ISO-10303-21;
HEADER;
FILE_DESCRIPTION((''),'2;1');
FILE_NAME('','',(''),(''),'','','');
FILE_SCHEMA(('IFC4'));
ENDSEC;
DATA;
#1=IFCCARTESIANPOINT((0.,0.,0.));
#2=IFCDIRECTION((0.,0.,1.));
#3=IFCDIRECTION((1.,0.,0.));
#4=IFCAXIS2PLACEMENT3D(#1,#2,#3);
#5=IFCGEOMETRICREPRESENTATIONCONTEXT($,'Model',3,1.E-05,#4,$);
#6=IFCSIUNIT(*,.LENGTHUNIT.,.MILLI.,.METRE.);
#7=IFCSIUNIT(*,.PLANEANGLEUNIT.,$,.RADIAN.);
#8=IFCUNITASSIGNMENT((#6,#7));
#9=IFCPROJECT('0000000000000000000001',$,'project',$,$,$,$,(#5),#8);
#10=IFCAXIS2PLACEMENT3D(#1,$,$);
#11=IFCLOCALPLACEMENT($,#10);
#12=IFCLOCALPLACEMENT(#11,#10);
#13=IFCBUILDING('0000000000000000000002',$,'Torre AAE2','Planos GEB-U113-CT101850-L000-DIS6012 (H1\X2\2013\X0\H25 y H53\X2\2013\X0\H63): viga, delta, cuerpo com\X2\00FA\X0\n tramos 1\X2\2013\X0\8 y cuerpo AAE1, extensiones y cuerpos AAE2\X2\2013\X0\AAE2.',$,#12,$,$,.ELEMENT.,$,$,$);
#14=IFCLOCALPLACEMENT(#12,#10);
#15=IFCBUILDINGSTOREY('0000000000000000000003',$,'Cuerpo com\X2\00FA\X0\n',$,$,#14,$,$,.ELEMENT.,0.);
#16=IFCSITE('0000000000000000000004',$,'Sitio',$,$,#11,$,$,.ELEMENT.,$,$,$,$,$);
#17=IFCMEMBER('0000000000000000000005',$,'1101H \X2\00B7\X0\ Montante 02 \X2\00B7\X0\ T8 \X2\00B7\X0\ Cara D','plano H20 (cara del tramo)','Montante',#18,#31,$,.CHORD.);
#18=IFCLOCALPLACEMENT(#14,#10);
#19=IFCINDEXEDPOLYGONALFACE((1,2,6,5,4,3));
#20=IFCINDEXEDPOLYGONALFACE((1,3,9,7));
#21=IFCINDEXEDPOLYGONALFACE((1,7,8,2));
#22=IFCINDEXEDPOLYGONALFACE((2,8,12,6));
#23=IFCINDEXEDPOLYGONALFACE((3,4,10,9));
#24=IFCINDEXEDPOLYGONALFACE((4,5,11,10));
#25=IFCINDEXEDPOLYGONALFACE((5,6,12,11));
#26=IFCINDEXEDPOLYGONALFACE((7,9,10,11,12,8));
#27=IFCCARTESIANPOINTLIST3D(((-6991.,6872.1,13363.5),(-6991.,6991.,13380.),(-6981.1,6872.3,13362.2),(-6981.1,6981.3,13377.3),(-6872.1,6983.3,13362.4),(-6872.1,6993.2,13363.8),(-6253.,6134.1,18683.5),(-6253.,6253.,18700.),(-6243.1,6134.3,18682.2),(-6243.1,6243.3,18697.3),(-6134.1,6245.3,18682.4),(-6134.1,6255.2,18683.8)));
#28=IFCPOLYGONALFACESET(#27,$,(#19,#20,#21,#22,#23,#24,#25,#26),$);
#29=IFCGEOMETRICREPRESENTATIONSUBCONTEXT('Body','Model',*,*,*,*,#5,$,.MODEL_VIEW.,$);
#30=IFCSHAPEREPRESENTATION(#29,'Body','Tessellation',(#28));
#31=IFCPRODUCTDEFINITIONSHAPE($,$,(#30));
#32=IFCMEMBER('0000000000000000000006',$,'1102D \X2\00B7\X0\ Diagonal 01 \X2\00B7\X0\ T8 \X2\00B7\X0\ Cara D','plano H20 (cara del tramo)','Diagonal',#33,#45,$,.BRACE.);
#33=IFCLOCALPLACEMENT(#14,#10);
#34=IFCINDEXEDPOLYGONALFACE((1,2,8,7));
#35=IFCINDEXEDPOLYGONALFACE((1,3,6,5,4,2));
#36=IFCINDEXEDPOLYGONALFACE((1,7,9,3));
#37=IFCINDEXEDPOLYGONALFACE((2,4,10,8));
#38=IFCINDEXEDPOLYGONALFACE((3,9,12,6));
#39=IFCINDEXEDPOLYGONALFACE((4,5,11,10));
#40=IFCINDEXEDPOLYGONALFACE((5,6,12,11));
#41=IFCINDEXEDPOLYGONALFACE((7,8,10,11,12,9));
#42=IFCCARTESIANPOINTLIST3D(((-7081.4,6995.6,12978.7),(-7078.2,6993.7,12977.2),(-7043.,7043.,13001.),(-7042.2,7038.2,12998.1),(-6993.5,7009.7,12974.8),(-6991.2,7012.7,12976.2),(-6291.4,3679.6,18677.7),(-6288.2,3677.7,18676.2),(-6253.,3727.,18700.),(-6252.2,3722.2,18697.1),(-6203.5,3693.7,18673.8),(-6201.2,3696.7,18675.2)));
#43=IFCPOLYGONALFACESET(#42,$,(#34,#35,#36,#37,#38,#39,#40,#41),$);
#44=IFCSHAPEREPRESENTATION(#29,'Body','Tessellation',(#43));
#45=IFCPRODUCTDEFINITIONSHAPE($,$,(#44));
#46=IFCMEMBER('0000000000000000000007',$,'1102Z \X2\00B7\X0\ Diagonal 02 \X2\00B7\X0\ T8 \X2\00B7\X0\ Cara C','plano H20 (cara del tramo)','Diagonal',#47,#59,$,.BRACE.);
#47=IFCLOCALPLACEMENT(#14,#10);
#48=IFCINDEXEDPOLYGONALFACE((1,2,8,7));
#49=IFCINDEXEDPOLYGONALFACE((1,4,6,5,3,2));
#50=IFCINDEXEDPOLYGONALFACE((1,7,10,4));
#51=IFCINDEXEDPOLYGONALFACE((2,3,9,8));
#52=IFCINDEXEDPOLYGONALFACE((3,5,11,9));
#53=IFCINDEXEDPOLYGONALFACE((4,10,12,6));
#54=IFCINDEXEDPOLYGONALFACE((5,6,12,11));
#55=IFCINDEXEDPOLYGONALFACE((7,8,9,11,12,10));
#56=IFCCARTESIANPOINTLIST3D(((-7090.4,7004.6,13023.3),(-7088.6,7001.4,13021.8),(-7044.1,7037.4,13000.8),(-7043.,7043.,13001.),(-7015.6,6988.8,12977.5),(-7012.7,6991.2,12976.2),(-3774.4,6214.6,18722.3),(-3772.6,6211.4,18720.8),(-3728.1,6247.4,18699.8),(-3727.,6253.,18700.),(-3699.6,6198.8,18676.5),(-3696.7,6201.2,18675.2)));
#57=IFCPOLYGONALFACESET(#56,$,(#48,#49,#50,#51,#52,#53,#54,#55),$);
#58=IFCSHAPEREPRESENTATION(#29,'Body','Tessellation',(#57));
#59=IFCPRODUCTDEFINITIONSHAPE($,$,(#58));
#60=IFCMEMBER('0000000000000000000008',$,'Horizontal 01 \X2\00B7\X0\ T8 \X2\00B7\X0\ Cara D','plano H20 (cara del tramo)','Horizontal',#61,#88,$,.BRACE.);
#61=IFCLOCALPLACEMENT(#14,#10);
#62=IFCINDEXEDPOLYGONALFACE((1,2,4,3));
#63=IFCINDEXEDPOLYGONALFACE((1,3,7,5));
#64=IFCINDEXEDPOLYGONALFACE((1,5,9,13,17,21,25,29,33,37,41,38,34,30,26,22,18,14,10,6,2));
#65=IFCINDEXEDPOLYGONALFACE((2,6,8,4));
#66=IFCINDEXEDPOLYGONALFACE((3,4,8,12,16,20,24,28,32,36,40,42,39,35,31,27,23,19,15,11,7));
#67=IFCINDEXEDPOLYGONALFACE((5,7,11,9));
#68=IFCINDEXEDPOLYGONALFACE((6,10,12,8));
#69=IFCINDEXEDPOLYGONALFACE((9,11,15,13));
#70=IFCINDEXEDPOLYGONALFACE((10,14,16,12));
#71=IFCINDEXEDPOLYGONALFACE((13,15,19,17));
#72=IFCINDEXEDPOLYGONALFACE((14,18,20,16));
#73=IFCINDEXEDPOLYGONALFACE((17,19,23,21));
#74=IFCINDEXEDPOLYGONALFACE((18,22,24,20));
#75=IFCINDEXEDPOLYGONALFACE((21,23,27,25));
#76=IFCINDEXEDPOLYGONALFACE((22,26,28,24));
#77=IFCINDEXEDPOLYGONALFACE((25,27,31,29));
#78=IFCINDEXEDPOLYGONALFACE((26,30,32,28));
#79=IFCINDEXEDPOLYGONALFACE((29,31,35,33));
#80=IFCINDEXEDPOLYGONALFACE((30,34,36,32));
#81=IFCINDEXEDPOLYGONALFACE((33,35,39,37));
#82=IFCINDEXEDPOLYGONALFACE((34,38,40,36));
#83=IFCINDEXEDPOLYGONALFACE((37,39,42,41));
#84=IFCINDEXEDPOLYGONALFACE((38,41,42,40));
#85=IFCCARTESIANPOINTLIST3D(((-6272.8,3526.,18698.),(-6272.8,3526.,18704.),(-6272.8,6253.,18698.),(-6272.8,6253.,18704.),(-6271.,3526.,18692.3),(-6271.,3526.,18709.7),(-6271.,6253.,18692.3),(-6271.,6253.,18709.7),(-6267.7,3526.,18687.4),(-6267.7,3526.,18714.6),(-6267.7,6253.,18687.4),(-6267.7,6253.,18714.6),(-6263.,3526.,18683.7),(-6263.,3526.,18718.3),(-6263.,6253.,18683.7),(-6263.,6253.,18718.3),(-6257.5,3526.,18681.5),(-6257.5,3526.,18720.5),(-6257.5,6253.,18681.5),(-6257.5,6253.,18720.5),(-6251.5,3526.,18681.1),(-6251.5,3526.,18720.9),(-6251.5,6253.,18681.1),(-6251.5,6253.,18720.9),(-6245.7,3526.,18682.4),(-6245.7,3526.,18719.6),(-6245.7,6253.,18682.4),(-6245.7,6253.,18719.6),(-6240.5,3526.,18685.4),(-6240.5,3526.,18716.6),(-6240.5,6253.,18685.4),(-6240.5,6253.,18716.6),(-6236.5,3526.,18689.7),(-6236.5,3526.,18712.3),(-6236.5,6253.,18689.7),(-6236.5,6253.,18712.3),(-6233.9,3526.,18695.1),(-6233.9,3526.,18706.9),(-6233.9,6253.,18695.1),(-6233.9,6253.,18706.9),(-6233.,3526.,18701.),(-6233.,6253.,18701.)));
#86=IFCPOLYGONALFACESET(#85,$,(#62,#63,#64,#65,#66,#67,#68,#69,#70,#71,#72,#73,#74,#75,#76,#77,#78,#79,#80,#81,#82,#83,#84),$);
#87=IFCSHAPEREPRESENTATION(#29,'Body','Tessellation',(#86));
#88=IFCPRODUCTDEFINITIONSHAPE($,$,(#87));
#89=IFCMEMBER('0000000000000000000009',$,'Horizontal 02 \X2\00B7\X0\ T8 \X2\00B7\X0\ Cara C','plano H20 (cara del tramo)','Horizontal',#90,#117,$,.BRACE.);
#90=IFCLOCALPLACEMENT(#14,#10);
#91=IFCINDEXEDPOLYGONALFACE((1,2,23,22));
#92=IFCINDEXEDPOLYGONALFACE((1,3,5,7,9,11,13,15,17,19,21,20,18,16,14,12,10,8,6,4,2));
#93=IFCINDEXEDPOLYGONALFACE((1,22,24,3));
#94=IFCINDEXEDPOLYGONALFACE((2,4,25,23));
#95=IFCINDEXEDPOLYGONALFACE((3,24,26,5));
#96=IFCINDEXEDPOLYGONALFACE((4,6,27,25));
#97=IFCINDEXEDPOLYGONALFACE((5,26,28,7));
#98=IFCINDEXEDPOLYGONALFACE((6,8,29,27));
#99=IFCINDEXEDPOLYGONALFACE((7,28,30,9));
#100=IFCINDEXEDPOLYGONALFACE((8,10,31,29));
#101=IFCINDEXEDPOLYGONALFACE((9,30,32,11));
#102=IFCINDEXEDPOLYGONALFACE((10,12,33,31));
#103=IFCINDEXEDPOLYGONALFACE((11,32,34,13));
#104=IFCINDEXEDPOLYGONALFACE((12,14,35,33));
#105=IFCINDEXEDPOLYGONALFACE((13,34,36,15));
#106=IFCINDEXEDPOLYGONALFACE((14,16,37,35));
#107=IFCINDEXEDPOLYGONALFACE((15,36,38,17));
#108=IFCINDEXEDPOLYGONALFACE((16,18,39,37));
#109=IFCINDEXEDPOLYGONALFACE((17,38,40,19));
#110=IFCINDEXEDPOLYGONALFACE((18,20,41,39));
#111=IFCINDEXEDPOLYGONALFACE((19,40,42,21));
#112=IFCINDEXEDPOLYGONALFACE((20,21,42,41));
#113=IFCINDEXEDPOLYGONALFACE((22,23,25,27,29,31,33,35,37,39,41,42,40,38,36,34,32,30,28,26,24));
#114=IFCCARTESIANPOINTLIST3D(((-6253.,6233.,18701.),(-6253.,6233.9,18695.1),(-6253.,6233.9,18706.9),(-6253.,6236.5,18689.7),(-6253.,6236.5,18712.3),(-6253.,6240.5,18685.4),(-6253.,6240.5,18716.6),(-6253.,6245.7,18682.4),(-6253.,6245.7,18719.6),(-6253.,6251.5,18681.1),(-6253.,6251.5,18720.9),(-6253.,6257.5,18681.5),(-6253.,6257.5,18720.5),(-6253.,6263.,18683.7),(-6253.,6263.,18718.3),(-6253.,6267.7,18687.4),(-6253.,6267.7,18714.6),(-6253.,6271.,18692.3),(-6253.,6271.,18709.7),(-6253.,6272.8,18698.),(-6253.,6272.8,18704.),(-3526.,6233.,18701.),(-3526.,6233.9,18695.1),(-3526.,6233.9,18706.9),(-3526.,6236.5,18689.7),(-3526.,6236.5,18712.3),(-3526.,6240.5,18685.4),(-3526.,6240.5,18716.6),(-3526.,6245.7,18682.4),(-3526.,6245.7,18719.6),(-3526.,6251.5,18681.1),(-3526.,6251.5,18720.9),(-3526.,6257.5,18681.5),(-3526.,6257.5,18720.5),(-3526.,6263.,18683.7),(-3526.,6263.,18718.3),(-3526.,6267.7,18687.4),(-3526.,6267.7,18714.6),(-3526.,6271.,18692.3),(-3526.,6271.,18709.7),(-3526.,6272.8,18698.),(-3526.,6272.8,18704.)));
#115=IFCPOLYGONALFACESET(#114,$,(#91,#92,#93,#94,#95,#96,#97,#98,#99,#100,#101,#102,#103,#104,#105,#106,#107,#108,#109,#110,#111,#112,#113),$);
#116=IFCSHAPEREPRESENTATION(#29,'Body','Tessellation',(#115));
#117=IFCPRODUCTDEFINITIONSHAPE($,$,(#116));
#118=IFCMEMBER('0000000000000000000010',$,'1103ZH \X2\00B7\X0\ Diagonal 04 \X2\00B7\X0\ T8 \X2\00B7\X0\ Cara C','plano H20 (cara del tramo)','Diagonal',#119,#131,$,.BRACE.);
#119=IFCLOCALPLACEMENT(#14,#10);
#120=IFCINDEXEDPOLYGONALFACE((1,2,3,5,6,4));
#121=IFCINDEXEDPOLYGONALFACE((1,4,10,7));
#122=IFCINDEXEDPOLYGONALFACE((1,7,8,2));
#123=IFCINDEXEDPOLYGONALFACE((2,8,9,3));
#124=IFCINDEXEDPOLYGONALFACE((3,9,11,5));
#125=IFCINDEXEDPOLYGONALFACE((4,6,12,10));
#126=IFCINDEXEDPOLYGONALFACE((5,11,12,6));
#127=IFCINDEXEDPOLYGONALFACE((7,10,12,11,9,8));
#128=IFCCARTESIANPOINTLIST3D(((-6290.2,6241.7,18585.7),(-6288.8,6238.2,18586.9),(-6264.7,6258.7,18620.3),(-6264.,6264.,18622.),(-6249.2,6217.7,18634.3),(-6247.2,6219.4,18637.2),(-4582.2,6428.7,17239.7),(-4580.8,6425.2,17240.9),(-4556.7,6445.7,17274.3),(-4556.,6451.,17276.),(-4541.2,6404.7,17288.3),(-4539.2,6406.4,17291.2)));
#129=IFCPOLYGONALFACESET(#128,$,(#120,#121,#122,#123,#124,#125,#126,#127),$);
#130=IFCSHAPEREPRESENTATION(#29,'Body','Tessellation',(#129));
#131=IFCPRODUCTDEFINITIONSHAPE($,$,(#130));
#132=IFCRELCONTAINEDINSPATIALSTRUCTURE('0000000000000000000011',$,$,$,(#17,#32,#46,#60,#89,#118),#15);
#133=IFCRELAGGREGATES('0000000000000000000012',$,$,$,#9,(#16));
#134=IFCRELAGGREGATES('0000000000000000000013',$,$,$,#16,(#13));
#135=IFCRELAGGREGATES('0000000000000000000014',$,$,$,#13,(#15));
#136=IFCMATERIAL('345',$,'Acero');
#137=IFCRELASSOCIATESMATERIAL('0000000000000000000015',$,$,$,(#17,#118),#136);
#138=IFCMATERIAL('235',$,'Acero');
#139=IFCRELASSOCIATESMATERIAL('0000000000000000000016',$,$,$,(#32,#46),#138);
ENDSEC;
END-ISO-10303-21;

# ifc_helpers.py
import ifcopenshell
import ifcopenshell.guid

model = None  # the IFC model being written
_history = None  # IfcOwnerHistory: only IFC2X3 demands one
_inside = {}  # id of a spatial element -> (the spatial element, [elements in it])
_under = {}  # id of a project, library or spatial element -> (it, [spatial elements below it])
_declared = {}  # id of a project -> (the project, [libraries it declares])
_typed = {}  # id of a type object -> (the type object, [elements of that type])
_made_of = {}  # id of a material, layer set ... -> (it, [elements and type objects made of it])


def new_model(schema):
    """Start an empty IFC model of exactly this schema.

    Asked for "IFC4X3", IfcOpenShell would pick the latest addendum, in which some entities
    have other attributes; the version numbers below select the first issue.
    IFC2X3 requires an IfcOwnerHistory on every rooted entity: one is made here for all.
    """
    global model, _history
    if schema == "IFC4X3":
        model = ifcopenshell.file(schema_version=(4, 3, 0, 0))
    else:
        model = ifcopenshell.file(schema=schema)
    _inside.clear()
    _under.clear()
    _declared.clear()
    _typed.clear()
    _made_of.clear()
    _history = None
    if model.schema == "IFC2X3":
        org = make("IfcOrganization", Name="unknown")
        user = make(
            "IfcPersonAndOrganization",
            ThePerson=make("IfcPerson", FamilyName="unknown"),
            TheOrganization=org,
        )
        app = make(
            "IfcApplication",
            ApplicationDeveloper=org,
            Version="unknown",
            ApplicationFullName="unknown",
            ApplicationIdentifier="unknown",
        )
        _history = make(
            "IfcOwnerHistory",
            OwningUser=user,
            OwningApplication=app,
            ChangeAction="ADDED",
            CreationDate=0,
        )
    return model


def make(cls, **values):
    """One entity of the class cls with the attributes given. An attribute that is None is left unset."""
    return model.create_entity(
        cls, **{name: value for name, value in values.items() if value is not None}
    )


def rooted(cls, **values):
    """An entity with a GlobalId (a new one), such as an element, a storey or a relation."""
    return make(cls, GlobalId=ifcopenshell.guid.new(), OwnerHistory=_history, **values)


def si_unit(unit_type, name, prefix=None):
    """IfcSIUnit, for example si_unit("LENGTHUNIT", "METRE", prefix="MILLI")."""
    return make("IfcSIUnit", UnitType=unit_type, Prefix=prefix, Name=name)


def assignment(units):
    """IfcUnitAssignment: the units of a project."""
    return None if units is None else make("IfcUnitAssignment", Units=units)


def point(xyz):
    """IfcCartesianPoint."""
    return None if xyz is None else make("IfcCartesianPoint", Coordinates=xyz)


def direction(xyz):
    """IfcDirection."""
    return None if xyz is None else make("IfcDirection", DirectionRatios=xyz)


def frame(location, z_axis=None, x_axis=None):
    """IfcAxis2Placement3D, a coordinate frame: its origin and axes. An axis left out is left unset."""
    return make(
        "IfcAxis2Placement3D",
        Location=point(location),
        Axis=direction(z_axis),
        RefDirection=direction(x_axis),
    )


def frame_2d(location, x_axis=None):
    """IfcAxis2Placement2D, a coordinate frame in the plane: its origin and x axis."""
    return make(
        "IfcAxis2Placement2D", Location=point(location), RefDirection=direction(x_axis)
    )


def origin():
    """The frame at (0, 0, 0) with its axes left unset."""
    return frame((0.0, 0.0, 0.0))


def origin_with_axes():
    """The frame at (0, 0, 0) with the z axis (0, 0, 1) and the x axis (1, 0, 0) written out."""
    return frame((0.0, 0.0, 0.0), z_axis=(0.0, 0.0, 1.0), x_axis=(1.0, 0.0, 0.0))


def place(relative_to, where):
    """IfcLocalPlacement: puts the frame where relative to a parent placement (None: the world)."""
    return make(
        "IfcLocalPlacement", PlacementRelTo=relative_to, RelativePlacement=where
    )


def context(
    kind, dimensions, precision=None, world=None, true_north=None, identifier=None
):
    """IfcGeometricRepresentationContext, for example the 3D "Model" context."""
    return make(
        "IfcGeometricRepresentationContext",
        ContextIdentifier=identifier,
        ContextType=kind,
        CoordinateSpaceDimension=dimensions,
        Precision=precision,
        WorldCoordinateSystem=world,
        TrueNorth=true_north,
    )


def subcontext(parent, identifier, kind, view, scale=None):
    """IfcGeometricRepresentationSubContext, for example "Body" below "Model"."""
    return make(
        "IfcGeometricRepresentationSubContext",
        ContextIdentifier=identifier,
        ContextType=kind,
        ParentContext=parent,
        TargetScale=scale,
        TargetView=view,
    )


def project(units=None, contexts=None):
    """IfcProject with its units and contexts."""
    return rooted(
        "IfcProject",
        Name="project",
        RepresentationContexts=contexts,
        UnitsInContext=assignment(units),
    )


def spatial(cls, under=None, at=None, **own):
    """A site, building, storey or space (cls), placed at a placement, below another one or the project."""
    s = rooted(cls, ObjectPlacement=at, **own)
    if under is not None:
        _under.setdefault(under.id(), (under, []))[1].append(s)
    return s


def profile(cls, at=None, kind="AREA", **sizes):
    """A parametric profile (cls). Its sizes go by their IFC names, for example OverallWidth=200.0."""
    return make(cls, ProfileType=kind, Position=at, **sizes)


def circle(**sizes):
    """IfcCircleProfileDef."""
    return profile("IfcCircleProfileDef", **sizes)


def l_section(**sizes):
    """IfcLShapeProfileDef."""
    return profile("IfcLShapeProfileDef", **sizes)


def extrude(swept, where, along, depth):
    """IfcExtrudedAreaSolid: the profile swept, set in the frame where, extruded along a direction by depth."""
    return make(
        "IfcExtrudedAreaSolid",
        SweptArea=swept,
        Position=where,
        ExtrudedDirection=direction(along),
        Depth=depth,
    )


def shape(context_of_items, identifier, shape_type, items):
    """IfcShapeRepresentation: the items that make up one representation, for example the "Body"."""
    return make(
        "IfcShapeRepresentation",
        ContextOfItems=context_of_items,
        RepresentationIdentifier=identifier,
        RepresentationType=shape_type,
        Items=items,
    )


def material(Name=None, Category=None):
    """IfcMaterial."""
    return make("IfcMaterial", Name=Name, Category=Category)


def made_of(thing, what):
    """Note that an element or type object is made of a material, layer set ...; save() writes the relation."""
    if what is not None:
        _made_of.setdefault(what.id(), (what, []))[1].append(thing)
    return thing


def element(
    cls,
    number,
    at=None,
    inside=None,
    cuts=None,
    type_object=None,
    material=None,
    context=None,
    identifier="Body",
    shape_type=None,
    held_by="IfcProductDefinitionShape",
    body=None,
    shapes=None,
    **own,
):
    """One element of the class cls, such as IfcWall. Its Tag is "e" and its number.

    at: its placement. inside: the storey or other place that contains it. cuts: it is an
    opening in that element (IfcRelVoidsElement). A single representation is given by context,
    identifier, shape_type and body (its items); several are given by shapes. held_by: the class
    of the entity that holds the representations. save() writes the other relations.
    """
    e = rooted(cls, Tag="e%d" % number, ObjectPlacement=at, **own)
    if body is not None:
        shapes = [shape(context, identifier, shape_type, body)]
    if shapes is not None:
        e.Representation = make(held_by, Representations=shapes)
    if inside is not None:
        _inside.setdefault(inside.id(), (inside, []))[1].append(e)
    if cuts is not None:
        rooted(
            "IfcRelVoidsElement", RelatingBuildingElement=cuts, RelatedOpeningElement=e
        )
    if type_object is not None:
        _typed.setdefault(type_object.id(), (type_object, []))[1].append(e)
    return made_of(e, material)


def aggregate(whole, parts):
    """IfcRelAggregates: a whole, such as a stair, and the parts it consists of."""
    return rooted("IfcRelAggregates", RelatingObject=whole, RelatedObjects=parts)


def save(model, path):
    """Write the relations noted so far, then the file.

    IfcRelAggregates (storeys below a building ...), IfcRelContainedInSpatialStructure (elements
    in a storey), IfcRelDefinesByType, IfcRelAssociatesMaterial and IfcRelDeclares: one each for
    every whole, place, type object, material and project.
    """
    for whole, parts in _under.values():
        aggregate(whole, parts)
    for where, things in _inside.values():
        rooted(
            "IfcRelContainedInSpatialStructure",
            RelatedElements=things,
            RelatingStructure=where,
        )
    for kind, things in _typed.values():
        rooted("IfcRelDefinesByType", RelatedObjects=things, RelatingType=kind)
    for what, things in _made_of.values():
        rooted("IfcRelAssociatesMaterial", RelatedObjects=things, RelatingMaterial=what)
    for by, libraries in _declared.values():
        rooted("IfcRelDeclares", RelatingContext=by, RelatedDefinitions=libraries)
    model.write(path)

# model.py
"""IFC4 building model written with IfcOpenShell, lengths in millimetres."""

from ifc_helpers import new_model, si_unit, frame, frame_2d, origin, origin_with_axes, place, context, subcontext, project, spatial, circle, l_section, extrude, material, element, save


model = new_model("IFC4")

# Units and contexts
model_context = context("Model", 3, precision=1e-05, world=origin_with_axes())
body_context = subcontext(model_context, "Body", "Model", "MODEL_VIEW")
ifc_project = project(units=[si_unit("LENGTHUNIT", "METRE", prefix="MILLI"), si_unit("PLANEANGLEUNIT", "RADIAN")], contexts=[model_context])

# Site, building, storey
site_placement = place(None, origin())
site = spatial("IfcSite", under=ifc_project, at=site_placement, Name="Sitio", CompositionType="ELEMENT")
building_placement = place(site_placement, origin())
building = spatial("IfcBuilding", under=site, at=building_placement, Name="Torre AAE2", Description="Planos GEB-U113-CT101850-L000-DIS6012 (H1–H25 y H53–H63): viga, delta, cuerpo común tramos 1–8 y cuerpo AAE1, extensiones y cuerpos AAE2–AAE2.", CompositionType="ELEMENT")
storey_placement = place(building_placement, origin())
storey = spatial("IfcBuildingStorey", under=building, at=storey_placement, Name="Cuerpo común", CompositionType="ELEMENT", Elevation=0.0)

# Members
ifc_material_1 = material(Name="235", Category="Acero")
ifc_material_2 = material(Name="345", Category="Acero")
member_1_placement = place(storey_placement, frame((-6253.0, 6253.0, 18700.0), z_axis=(-0.136127, 0.136127, -0.981295), x_axis=(0.990691, 0.018705, -0.134836)))
element("IfcMember", 1, at=member_1_placement, inside=storey, material=ifc_material_2, Name="1101H · Montante 02 · T8 · Cara D", Description="plano H20 (cara del tramo)", ObjectType="Montante", PredefinedType="CHORD", context=body_context, shape_type="SweptSolid", body=[
    extrude(l_section(Depth=120.0, Width=120.0, Thickness=10.0, at=frame_2d((60.0, 60.0))), None, (0.0, 0.0, 1.0), 5421.4),
])
for number, where, z_axis, x_axis, name in (
    (2, (-6253.0, 3727.0, 18700.0), (-0.118964, 0.499347, -0.858196), (0.797631, -0.466671, -0.382104), "1102D · Diagonal 01 · T8 · Cara D"),
    (3, (-3727.0, 6253.0, 18700.0), (-0.499347, 0.118964, -0.858196), (0.466671, -0.797631, -0.382104), "1102Z · Diagonal 02 · T8 · Cara C"),
):
    element("IfcMember", number, at=place(storey_placement, frame(where, z_axis=z_axis, x_axis=x_axis)), inside=storey, material=ifc_material_1, Name=name, Description="plano H20 (cara del tramo)", ObjectType="Diagonal", PredefinedType="BRACE", context=body_context, shape_type="SweptSolid", body=[
        extrude(l_section(Depth=65.0, Width=65.0, Thickness=4.0, at=frame_2d((32.5, 32.5))), None, (0.0, 0.0, 1.0), 6640.7),
    ])
for number, where, z_axis, x_axis, name in (
    (4, (-6253.0, 6253.0, 18701.0), (0.0, -1.0, 0.0), (1.0, 0.0, 0.0), "Horizontal 01 · T8 · Cara D"),
    (5, (-6253.0, 6253.0, 18701.0), (1.0, 0.0, 0.0), (0.0, -1.0, 0.0), "Horizontal 02 · T8 · Cara C"),
):
    element("IfcMember", number, at=place(storey_placement, frame(where, z_axis=z_axis, x_axis=x_axis)), inside=storey, Name=name, Description="plano H20 (cara del tramo)", ObjectType="Horizontal", PredefinedType="BRACE", context=body_context, shape_type="SweptSolid", body=[
        extrude(circle(Radius=20.0), None, (0.0, 0.0, 1.0), 2727.0),
    ])
member_2_placement = place(storey_placement, frame((-6264.0, 6264.0, 18622.0), z_axis=(0.782536, 0.085676, -0.616682), x_axis=(0.336961, -0.891166, 0.303776)))
element("IfcMember", 6, at=member_2_placement, inside=storey, material=ifc_material_2, Name="1103ZH · Diagonal 04 · T8 · Cara C", Description="plano H20 (cara del tramo)", ObjectType="Diagonal", PredefinedType="BRACE", context=body_context, shape_type="SweptSolid", body=[
    extrude(l_section(Depth=50.0, Width=50.0, Thickness=4.0, at=frame_2d((25.0, 25.0))), None, (0.0, 0.0, 1.0), 2182.6),
])

save(model, "model.ifc")
